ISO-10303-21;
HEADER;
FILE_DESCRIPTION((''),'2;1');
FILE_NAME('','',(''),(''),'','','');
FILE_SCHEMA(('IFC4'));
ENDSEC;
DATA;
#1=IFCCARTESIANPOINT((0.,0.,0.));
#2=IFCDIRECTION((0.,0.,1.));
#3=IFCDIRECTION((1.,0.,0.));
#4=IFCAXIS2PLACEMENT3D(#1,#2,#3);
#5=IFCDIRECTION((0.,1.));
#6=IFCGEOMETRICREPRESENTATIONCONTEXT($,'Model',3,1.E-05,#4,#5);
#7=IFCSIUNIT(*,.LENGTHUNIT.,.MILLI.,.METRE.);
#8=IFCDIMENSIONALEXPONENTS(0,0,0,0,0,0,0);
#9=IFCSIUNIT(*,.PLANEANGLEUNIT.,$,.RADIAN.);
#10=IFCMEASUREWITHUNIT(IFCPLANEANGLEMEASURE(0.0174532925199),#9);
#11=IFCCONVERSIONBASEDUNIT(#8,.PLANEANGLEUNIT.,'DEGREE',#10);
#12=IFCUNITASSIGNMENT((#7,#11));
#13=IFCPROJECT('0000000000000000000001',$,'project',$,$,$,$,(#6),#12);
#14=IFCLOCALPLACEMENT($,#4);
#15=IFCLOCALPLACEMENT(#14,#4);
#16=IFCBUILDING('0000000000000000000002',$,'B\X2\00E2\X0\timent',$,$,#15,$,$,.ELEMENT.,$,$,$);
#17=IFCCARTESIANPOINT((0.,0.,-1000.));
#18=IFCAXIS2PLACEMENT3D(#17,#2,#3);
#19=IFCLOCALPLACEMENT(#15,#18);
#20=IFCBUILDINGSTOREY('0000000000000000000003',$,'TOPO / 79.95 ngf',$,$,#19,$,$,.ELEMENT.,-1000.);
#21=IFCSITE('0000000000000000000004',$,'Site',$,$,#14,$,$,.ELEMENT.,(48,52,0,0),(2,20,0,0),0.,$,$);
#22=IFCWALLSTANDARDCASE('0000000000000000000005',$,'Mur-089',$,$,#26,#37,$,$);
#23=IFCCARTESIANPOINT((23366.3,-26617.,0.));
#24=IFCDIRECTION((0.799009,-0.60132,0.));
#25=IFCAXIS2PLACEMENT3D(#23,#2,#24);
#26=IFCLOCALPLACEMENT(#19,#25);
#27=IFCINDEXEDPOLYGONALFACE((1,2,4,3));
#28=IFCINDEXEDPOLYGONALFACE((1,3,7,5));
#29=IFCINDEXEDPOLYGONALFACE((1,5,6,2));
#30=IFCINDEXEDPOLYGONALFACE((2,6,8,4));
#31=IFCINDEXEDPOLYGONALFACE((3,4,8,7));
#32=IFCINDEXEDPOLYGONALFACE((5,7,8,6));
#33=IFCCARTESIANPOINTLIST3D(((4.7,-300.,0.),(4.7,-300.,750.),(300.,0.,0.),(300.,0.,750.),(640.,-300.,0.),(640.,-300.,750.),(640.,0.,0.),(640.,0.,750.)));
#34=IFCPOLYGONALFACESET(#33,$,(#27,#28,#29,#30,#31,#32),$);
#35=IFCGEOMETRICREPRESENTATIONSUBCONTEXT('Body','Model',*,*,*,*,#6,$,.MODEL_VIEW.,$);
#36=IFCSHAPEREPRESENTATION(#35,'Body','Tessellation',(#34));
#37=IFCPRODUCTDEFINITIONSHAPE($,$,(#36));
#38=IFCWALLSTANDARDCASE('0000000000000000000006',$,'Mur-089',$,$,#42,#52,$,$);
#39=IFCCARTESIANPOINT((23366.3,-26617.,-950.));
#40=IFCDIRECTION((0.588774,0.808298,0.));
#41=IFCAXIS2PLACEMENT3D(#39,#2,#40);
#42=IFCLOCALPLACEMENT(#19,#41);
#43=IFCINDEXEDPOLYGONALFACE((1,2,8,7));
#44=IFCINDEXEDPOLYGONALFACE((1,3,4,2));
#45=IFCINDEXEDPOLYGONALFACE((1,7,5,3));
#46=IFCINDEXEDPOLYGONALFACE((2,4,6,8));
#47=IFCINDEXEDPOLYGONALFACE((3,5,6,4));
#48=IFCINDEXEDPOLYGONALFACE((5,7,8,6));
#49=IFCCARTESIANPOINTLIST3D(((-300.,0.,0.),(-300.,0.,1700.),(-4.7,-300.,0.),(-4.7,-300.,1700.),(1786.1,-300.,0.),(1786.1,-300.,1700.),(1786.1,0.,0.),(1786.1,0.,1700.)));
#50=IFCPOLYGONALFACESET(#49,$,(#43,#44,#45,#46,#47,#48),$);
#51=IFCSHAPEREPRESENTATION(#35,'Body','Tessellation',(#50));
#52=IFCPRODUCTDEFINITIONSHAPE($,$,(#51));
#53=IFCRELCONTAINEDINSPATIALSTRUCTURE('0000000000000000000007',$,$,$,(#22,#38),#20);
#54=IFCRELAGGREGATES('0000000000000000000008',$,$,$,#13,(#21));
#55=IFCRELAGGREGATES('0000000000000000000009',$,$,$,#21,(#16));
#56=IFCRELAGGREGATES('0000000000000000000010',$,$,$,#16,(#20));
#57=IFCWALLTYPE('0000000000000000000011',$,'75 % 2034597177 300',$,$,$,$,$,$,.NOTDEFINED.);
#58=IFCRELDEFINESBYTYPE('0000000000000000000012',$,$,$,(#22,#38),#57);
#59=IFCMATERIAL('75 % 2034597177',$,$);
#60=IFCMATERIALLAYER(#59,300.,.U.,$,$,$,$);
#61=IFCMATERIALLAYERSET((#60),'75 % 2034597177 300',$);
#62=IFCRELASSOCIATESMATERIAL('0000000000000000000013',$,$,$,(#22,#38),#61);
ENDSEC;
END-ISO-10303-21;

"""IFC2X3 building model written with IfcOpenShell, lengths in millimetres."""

from ifc_helpers import new_model, entity, si_unit, converted_unit, direction, frame, origin_with_axes, place, context, subcontext, project, spatial, polyline, outline, extrude, material, layer, layer_set, layer_usage, type_object, element, save


model = new_model("IFC2X3")

# Units and contexts
model_context = context("Model", 3, precision=1e-05, world=origin_with_axes(), true_north=direction((0.0, 1.0)))
body_context = subcontext(model_context, "Body", "Model", "MODEL_VIEW")
ifc_project = project(units=[si_unit("LENGTHUNIT", "METRE", prefix="MILLI"), converted_unit("PLANEANGLEUNIT", "DEGREE", entity("IfcPlaneAngleMeasure", 0.0174532925199), si_unit("PLANEANGLEUNIT", "RADIAN"), dimensions=[0, 0, 0, 0, 0, 0, 0])], contexts=[model_context])

# Site, building, storey
site_placement = place(None, origin_with_axes())
site = spatial("IfcSite", under=ifc_project, at=site_placement, Name="Site", CompositionType="ELEMENT", RefLatitude=(48, 52, 0, 0), RefLongitude=(2, 20, 0, 0), RefElevation=0.0)
building_placement = place(site_placement, origin_with_axes())
building = spatial("IfcBuilding", under=site, at=building_placement, Name="Bâtiment", CompositionType="ELEMENT")
storey_placement = place(building_placement, frame((0.0, 0.0, -1000.0), z_axis=(0.0, 0.0, 1.0), x_axis=(1.0, 0.0, 0.0)))
storey = spatial("IfcBuildingStorey", under=building, at=storey_placement, Name="TOPO / 79.95 ngf", CompositionType="ELEMENT", Elevation=-1000.0)

# Walls
ifc_material_1 = material(Name="75 % 2034597177")
ifc_layer_1 = layer(ifc_material_1, 300.0, ventilated="UNKNOWN")
ifc_layer_set_1 = layer_set([ifc_layer_1], Name="75 % 2034597177 300")
wall_type_1 = type_object("IfcWallType", Name="75 % 2034597177 300", PredefinedType="NOTDEFINED")
ifc_layer_usage_1 = layer_usage(ifc_layer_set_1, "AXIS2", "POSITIVE", -300.0)
wall_1_placement = place(storey_placement, frame((23366.3, -26617.0, 0.0), z_axis=(0.0, 0.0, 1.0), x_axis=(0.799009, -0.60132, 0.0)))
element("IfcWallStandardCase", 1, at=wall_1_placement, inside=storey, type_object=wall_type_1, material=ifc_layer_usage_1, Name="Mur-089", context=body_context, shape_type="SweptSolid", body=[
    extrude(outline(polyline([(4.7, -300.0), (640.0, -300.0), (640.0, 0.0), (300.0, 0.0), (4.7, -300.0)])), origin_with_axes(), (0.0, 0.0, 1.0), 750.0),
])
ifc_layer_usage_2 = layer_usage(ifc_layer_set_1, "AXIS2", "POSITIVE", -300.0)
wall_2_placement = place(storey_placement, frame((23366.3, -26617.0, -950.0), z_axis=(0.0, 0.0, 1.0), x_axis=(0.588774, 0.808298, 0.0)))
element("IfcWallStandardCase", 2, at=wall_2_placement, inside=storey, type_object=wall_type_1, material=ifc_layer_usage_2, Name="Mur-089", context=body_context, shape_type="SweptSolid", body=[
    extrude(outline(polyline([(-4.7, -300.0), (1786.1, -300.0), (1786.1, 0.0), (-300.0, 0.0), (-4.7, -300.0)])), origin_with_axes(), (0.0, 0.0, 1.0), 1700.0),
])

save(model, "model.ifc")
